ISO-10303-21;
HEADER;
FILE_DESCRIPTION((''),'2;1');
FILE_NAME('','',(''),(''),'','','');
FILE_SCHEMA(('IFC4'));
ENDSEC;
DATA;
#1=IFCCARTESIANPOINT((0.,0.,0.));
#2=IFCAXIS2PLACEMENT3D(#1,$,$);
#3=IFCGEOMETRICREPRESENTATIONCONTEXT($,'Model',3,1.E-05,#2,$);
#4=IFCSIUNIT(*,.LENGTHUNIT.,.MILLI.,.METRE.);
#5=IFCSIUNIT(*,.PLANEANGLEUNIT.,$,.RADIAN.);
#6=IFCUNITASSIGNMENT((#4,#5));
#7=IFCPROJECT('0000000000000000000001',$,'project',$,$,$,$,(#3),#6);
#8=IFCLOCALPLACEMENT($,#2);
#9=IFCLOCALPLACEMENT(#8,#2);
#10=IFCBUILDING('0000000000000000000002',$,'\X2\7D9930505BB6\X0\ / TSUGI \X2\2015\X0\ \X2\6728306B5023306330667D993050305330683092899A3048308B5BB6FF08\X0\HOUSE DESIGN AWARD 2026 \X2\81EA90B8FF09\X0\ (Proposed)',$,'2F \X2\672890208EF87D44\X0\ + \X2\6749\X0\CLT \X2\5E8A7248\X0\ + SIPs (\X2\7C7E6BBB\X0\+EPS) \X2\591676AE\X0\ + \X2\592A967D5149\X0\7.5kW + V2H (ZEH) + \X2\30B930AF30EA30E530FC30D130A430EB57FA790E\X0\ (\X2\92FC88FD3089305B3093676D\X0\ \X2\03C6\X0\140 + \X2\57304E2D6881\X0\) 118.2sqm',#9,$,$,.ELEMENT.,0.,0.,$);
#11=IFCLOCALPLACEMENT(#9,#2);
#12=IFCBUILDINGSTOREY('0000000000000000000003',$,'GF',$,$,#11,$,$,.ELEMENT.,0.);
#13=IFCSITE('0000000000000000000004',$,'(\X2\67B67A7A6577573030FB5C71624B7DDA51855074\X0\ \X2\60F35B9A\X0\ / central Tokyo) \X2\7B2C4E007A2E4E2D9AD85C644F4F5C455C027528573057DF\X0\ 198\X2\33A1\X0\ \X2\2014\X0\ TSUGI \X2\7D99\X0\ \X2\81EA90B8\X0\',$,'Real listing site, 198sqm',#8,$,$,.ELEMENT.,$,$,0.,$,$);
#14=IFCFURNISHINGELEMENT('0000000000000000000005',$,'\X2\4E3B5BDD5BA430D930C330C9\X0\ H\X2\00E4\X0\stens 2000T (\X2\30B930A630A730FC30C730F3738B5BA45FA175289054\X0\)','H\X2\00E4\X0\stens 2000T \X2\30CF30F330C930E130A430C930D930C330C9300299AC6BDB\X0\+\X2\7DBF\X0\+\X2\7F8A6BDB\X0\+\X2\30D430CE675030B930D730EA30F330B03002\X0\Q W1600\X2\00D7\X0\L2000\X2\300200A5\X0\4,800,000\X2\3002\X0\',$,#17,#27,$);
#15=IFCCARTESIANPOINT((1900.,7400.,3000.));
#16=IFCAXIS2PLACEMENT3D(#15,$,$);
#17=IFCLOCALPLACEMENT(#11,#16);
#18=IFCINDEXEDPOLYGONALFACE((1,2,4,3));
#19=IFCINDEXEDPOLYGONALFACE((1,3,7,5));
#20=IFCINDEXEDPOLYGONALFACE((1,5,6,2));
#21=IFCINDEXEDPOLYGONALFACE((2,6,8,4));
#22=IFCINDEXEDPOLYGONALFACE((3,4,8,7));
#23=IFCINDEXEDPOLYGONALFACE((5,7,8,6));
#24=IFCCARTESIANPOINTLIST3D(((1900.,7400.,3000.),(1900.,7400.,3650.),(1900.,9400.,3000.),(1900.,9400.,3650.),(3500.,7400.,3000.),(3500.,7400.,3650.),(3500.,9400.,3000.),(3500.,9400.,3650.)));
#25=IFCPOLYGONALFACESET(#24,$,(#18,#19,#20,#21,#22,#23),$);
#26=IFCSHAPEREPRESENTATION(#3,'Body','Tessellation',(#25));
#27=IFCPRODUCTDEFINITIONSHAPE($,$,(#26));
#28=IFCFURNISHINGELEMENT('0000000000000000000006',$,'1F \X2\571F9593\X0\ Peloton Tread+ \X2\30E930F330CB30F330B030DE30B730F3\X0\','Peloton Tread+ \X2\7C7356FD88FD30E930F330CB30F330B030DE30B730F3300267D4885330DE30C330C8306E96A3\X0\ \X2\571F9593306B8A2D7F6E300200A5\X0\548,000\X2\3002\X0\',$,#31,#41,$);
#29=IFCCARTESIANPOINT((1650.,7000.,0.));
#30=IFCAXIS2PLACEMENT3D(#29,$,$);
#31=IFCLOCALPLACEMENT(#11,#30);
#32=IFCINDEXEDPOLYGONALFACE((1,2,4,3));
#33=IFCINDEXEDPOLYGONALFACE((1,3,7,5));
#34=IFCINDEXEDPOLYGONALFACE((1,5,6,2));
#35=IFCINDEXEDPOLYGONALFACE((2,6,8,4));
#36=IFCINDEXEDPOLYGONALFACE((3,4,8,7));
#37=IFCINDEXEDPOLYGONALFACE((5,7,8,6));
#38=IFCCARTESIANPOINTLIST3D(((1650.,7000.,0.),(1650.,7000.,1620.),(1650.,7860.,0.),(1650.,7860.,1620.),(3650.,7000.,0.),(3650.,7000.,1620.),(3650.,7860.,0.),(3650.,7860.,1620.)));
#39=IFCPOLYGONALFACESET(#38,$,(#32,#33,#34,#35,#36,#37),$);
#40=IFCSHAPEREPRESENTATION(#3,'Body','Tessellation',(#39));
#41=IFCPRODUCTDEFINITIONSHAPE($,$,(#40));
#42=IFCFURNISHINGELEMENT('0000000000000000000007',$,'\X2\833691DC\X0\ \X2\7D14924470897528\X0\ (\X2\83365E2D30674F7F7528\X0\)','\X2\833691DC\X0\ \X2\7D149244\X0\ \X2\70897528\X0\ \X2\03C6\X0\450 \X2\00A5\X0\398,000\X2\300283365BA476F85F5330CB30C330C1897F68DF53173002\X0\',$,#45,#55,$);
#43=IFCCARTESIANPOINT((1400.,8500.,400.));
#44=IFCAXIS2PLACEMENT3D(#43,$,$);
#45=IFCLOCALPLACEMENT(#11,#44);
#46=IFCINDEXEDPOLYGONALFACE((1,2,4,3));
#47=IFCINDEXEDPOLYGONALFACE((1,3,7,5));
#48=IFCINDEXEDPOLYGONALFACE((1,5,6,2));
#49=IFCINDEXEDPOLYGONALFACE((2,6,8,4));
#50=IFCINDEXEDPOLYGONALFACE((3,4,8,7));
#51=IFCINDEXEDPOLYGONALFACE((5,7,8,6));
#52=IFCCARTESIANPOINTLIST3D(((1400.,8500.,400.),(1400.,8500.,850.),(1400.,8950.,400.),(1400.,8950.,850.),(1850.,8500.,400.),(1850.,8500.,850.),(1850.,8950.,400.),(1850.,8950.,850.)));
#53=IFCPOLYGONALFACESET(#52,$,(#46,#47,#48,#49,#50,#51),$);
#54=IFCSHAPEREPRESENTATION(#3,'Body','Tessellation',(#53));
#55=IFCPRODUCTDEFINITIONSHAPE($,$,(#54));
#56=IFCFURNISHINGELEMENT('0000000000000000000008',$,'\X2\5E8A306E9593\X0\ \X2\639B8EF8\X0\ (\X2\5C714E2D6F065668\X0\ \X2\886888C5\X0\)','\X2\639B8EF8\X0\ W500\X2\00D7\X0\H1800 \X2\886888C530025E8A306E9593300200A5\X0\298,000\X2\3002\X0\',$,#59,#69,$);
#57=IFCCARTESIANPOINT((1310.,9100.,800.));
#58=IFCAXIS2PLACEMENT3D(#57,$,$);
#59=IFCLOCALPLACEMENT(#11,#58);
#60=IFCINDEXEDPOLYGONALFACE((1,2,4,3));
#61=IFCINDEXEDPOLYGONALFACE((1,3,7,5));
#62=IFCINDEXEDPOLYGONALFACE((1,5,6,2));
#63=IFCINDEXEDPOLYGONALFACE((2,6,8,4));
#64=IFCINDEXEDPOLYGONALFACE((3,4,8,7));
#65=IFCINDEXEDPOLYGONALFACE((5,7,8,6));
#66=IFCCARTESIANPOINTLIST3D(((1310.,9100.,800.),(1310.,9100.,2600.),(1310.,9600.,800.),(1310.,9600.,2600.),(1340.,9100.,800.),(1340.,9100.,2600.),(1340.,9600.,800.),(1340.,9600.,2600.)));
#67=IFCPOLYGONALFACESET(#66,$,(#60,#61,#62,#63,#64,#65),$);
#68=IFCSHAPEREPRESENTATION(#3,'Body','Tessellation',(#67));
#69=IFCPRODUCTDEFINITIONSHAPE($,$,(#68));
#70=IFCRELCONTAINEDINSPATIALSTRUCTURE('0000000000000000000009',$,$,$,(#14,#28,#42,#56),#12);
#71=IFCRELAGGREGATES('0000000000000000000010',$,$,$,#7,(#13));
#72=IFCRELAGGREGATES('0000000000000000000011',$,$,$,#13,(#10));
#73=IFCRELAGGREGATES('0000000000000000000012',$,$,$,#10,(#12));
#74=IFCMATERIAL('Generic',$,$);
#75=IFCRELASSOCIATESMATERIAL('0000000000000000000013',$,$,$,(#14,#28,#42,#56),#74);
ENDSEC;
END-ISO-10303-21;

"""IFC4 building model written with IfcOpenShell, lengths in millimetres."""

from ifc_helpers import new_model, si_unit, frame, frame_2d, origin, place, context, project, spatial, rectangle, extrude, material, element, save


model = new_model("IFC4")

# Units and contexts
model_context = context("Model", 3, precision=1e-05, world=origin())
ifc_project = project(units=[si_unit("LENGTHUNIT", "METRE", prefix="MILLI"), si_unit("PLANEANGLEUNIT", "RADIAN")], contexts=[model_context])

# Site, building, storey
site_placement = place(None, origin())
site = spatial("IfcSite", under=ifc_project, at=site_placement, Name="(架空敷地・山手線内側 想定 / central Tokyo) 第一種中高層住居専用地域 198㎡ — TSUGI 継 自邸", ObjectType="Real listing site, 198sqm", CompositionType="ELEMENT", RefElevation=0.0)
building_placement = place(site_placement, origin())
building = spatial("IfcBuilding", under=site, at=building_placement, Name="継ぐ家 / TSUGI ― 木に倣って継ぐことを覚える家（HOUSE DESIGN AWARD 2026 自邸） (Proposed)", ObjectType="2F 木造軸組 + 杉CLT 床版 + SIPs (籾殻+EPS) 外皮 + 太陽光7.5kW + V2H (ZEH) + スクリューパイル基礎 (鋼製らせん杭 φ140 + 地中梁) 118.2sqm", CompositionType="ELEMENT", ElevationOfRefHeight=0.0, ElevationOfTerrain=0.0)
storey_placement = place(building_placement, origin())
storey = spatial("IfcBuildingStorey", under=building, at=storey_placement, Name="GF", CompositionType="ELEMENT", Elevation=0.0)

# Shared definitions
ifc_material_1 = material(Name="Generic")

# Furnishing elements
furnishing_1_placement = place(storey_placement, frame((1900.0, 7400.0, 3000.0)))
element("IfcFurnishingElement", 1, at=furnishing_1_placement, inside=storey, material=ifc_material_1, Name="主寝室ベッド Hästens 2000T (スウェーデン王室御用達)", Description="Hästens 2000T ハンドメイドベッド。馬毛+綿+羊毛+ピノ材スプリング。Q W1600×L2000。¥4,800,000。", context=model_context, shape_type="SweptSolid", body=[
    extrude(rectangle(XDim=1600.0, YDim=2000.0, at=frame_2d((800.0, 1000.0))), frame((1900.0, 7400.0, 3000.0)), (0.0, 0.0, 1.0), 650.0),
])
furnishing_2_placement = place(storey_placement, frame((1650.0, 7000.0, 0.0)))
element("IfcFurnishingElement", 2, at=furnishing_2_placement, inside=storey, material=ifc_material_1, Name="1F 土間 Peloton Tread+ ランニングマシン", Description="Peloton Tread+ 米国製ランニングマシン。柔術マットの隣 土間に設置。¥548,000。", context=model_context, shape_type="SweptSolid", body=[
    extrude(rectangle(XDim=2000.0, YDim=860.0, at=frame_2d((1000.0, 430.0))), frame((1650.0, 7000.0, 0.0)), (0.0, 0.0, 1.0), 1620.0),
])
furnishing_3_placement = place(storey_placement, frame((1400.0, 8500.0, 400.0)))
element("IfcFurnishingElement", 3, at=furnishing_3_placement, inside=storey, material=ifc_material_1, Name="茶釜 純鉄炉用 (茶席で使用)", Description="茶釜 純鉄 炉用 φ450 ¥398,000。茶室相当ニッチ西棟北。", context=model_context, shape_type="SweptSolid", body=[
    extrude(rectangle(XDim=450.0, YDim=450.0, at=frame_2d((225.0, 225.0))), frame((1400.0, 8500.0, 400.0)), (0.0, 0.0, 1.0), 450.0),
])
furnishing_4_placement = place(storey_placement, frame((1310.0, 9100.0, 800.0)))
element("IfcFurnishingElement", 4, at=furnishing_4_placement, inside=storey, material=ifc_material_1, Name="床の間 掛軸 (山中漆器 表装)", Description="掛軸 W500×H1800 表装。床の間。¥298,000。", context=model_context, shape_type="SweptSolid", body=[
    extrude(rectangle(XDim=30.0, YDim=500.0, at=frame_2d((15.0, 250.0))), frame((1310.0, 9100.0, 800.0)), (0.0, 0.0, 1.0), 1800.0),
])

save(model, "model.ifc")
